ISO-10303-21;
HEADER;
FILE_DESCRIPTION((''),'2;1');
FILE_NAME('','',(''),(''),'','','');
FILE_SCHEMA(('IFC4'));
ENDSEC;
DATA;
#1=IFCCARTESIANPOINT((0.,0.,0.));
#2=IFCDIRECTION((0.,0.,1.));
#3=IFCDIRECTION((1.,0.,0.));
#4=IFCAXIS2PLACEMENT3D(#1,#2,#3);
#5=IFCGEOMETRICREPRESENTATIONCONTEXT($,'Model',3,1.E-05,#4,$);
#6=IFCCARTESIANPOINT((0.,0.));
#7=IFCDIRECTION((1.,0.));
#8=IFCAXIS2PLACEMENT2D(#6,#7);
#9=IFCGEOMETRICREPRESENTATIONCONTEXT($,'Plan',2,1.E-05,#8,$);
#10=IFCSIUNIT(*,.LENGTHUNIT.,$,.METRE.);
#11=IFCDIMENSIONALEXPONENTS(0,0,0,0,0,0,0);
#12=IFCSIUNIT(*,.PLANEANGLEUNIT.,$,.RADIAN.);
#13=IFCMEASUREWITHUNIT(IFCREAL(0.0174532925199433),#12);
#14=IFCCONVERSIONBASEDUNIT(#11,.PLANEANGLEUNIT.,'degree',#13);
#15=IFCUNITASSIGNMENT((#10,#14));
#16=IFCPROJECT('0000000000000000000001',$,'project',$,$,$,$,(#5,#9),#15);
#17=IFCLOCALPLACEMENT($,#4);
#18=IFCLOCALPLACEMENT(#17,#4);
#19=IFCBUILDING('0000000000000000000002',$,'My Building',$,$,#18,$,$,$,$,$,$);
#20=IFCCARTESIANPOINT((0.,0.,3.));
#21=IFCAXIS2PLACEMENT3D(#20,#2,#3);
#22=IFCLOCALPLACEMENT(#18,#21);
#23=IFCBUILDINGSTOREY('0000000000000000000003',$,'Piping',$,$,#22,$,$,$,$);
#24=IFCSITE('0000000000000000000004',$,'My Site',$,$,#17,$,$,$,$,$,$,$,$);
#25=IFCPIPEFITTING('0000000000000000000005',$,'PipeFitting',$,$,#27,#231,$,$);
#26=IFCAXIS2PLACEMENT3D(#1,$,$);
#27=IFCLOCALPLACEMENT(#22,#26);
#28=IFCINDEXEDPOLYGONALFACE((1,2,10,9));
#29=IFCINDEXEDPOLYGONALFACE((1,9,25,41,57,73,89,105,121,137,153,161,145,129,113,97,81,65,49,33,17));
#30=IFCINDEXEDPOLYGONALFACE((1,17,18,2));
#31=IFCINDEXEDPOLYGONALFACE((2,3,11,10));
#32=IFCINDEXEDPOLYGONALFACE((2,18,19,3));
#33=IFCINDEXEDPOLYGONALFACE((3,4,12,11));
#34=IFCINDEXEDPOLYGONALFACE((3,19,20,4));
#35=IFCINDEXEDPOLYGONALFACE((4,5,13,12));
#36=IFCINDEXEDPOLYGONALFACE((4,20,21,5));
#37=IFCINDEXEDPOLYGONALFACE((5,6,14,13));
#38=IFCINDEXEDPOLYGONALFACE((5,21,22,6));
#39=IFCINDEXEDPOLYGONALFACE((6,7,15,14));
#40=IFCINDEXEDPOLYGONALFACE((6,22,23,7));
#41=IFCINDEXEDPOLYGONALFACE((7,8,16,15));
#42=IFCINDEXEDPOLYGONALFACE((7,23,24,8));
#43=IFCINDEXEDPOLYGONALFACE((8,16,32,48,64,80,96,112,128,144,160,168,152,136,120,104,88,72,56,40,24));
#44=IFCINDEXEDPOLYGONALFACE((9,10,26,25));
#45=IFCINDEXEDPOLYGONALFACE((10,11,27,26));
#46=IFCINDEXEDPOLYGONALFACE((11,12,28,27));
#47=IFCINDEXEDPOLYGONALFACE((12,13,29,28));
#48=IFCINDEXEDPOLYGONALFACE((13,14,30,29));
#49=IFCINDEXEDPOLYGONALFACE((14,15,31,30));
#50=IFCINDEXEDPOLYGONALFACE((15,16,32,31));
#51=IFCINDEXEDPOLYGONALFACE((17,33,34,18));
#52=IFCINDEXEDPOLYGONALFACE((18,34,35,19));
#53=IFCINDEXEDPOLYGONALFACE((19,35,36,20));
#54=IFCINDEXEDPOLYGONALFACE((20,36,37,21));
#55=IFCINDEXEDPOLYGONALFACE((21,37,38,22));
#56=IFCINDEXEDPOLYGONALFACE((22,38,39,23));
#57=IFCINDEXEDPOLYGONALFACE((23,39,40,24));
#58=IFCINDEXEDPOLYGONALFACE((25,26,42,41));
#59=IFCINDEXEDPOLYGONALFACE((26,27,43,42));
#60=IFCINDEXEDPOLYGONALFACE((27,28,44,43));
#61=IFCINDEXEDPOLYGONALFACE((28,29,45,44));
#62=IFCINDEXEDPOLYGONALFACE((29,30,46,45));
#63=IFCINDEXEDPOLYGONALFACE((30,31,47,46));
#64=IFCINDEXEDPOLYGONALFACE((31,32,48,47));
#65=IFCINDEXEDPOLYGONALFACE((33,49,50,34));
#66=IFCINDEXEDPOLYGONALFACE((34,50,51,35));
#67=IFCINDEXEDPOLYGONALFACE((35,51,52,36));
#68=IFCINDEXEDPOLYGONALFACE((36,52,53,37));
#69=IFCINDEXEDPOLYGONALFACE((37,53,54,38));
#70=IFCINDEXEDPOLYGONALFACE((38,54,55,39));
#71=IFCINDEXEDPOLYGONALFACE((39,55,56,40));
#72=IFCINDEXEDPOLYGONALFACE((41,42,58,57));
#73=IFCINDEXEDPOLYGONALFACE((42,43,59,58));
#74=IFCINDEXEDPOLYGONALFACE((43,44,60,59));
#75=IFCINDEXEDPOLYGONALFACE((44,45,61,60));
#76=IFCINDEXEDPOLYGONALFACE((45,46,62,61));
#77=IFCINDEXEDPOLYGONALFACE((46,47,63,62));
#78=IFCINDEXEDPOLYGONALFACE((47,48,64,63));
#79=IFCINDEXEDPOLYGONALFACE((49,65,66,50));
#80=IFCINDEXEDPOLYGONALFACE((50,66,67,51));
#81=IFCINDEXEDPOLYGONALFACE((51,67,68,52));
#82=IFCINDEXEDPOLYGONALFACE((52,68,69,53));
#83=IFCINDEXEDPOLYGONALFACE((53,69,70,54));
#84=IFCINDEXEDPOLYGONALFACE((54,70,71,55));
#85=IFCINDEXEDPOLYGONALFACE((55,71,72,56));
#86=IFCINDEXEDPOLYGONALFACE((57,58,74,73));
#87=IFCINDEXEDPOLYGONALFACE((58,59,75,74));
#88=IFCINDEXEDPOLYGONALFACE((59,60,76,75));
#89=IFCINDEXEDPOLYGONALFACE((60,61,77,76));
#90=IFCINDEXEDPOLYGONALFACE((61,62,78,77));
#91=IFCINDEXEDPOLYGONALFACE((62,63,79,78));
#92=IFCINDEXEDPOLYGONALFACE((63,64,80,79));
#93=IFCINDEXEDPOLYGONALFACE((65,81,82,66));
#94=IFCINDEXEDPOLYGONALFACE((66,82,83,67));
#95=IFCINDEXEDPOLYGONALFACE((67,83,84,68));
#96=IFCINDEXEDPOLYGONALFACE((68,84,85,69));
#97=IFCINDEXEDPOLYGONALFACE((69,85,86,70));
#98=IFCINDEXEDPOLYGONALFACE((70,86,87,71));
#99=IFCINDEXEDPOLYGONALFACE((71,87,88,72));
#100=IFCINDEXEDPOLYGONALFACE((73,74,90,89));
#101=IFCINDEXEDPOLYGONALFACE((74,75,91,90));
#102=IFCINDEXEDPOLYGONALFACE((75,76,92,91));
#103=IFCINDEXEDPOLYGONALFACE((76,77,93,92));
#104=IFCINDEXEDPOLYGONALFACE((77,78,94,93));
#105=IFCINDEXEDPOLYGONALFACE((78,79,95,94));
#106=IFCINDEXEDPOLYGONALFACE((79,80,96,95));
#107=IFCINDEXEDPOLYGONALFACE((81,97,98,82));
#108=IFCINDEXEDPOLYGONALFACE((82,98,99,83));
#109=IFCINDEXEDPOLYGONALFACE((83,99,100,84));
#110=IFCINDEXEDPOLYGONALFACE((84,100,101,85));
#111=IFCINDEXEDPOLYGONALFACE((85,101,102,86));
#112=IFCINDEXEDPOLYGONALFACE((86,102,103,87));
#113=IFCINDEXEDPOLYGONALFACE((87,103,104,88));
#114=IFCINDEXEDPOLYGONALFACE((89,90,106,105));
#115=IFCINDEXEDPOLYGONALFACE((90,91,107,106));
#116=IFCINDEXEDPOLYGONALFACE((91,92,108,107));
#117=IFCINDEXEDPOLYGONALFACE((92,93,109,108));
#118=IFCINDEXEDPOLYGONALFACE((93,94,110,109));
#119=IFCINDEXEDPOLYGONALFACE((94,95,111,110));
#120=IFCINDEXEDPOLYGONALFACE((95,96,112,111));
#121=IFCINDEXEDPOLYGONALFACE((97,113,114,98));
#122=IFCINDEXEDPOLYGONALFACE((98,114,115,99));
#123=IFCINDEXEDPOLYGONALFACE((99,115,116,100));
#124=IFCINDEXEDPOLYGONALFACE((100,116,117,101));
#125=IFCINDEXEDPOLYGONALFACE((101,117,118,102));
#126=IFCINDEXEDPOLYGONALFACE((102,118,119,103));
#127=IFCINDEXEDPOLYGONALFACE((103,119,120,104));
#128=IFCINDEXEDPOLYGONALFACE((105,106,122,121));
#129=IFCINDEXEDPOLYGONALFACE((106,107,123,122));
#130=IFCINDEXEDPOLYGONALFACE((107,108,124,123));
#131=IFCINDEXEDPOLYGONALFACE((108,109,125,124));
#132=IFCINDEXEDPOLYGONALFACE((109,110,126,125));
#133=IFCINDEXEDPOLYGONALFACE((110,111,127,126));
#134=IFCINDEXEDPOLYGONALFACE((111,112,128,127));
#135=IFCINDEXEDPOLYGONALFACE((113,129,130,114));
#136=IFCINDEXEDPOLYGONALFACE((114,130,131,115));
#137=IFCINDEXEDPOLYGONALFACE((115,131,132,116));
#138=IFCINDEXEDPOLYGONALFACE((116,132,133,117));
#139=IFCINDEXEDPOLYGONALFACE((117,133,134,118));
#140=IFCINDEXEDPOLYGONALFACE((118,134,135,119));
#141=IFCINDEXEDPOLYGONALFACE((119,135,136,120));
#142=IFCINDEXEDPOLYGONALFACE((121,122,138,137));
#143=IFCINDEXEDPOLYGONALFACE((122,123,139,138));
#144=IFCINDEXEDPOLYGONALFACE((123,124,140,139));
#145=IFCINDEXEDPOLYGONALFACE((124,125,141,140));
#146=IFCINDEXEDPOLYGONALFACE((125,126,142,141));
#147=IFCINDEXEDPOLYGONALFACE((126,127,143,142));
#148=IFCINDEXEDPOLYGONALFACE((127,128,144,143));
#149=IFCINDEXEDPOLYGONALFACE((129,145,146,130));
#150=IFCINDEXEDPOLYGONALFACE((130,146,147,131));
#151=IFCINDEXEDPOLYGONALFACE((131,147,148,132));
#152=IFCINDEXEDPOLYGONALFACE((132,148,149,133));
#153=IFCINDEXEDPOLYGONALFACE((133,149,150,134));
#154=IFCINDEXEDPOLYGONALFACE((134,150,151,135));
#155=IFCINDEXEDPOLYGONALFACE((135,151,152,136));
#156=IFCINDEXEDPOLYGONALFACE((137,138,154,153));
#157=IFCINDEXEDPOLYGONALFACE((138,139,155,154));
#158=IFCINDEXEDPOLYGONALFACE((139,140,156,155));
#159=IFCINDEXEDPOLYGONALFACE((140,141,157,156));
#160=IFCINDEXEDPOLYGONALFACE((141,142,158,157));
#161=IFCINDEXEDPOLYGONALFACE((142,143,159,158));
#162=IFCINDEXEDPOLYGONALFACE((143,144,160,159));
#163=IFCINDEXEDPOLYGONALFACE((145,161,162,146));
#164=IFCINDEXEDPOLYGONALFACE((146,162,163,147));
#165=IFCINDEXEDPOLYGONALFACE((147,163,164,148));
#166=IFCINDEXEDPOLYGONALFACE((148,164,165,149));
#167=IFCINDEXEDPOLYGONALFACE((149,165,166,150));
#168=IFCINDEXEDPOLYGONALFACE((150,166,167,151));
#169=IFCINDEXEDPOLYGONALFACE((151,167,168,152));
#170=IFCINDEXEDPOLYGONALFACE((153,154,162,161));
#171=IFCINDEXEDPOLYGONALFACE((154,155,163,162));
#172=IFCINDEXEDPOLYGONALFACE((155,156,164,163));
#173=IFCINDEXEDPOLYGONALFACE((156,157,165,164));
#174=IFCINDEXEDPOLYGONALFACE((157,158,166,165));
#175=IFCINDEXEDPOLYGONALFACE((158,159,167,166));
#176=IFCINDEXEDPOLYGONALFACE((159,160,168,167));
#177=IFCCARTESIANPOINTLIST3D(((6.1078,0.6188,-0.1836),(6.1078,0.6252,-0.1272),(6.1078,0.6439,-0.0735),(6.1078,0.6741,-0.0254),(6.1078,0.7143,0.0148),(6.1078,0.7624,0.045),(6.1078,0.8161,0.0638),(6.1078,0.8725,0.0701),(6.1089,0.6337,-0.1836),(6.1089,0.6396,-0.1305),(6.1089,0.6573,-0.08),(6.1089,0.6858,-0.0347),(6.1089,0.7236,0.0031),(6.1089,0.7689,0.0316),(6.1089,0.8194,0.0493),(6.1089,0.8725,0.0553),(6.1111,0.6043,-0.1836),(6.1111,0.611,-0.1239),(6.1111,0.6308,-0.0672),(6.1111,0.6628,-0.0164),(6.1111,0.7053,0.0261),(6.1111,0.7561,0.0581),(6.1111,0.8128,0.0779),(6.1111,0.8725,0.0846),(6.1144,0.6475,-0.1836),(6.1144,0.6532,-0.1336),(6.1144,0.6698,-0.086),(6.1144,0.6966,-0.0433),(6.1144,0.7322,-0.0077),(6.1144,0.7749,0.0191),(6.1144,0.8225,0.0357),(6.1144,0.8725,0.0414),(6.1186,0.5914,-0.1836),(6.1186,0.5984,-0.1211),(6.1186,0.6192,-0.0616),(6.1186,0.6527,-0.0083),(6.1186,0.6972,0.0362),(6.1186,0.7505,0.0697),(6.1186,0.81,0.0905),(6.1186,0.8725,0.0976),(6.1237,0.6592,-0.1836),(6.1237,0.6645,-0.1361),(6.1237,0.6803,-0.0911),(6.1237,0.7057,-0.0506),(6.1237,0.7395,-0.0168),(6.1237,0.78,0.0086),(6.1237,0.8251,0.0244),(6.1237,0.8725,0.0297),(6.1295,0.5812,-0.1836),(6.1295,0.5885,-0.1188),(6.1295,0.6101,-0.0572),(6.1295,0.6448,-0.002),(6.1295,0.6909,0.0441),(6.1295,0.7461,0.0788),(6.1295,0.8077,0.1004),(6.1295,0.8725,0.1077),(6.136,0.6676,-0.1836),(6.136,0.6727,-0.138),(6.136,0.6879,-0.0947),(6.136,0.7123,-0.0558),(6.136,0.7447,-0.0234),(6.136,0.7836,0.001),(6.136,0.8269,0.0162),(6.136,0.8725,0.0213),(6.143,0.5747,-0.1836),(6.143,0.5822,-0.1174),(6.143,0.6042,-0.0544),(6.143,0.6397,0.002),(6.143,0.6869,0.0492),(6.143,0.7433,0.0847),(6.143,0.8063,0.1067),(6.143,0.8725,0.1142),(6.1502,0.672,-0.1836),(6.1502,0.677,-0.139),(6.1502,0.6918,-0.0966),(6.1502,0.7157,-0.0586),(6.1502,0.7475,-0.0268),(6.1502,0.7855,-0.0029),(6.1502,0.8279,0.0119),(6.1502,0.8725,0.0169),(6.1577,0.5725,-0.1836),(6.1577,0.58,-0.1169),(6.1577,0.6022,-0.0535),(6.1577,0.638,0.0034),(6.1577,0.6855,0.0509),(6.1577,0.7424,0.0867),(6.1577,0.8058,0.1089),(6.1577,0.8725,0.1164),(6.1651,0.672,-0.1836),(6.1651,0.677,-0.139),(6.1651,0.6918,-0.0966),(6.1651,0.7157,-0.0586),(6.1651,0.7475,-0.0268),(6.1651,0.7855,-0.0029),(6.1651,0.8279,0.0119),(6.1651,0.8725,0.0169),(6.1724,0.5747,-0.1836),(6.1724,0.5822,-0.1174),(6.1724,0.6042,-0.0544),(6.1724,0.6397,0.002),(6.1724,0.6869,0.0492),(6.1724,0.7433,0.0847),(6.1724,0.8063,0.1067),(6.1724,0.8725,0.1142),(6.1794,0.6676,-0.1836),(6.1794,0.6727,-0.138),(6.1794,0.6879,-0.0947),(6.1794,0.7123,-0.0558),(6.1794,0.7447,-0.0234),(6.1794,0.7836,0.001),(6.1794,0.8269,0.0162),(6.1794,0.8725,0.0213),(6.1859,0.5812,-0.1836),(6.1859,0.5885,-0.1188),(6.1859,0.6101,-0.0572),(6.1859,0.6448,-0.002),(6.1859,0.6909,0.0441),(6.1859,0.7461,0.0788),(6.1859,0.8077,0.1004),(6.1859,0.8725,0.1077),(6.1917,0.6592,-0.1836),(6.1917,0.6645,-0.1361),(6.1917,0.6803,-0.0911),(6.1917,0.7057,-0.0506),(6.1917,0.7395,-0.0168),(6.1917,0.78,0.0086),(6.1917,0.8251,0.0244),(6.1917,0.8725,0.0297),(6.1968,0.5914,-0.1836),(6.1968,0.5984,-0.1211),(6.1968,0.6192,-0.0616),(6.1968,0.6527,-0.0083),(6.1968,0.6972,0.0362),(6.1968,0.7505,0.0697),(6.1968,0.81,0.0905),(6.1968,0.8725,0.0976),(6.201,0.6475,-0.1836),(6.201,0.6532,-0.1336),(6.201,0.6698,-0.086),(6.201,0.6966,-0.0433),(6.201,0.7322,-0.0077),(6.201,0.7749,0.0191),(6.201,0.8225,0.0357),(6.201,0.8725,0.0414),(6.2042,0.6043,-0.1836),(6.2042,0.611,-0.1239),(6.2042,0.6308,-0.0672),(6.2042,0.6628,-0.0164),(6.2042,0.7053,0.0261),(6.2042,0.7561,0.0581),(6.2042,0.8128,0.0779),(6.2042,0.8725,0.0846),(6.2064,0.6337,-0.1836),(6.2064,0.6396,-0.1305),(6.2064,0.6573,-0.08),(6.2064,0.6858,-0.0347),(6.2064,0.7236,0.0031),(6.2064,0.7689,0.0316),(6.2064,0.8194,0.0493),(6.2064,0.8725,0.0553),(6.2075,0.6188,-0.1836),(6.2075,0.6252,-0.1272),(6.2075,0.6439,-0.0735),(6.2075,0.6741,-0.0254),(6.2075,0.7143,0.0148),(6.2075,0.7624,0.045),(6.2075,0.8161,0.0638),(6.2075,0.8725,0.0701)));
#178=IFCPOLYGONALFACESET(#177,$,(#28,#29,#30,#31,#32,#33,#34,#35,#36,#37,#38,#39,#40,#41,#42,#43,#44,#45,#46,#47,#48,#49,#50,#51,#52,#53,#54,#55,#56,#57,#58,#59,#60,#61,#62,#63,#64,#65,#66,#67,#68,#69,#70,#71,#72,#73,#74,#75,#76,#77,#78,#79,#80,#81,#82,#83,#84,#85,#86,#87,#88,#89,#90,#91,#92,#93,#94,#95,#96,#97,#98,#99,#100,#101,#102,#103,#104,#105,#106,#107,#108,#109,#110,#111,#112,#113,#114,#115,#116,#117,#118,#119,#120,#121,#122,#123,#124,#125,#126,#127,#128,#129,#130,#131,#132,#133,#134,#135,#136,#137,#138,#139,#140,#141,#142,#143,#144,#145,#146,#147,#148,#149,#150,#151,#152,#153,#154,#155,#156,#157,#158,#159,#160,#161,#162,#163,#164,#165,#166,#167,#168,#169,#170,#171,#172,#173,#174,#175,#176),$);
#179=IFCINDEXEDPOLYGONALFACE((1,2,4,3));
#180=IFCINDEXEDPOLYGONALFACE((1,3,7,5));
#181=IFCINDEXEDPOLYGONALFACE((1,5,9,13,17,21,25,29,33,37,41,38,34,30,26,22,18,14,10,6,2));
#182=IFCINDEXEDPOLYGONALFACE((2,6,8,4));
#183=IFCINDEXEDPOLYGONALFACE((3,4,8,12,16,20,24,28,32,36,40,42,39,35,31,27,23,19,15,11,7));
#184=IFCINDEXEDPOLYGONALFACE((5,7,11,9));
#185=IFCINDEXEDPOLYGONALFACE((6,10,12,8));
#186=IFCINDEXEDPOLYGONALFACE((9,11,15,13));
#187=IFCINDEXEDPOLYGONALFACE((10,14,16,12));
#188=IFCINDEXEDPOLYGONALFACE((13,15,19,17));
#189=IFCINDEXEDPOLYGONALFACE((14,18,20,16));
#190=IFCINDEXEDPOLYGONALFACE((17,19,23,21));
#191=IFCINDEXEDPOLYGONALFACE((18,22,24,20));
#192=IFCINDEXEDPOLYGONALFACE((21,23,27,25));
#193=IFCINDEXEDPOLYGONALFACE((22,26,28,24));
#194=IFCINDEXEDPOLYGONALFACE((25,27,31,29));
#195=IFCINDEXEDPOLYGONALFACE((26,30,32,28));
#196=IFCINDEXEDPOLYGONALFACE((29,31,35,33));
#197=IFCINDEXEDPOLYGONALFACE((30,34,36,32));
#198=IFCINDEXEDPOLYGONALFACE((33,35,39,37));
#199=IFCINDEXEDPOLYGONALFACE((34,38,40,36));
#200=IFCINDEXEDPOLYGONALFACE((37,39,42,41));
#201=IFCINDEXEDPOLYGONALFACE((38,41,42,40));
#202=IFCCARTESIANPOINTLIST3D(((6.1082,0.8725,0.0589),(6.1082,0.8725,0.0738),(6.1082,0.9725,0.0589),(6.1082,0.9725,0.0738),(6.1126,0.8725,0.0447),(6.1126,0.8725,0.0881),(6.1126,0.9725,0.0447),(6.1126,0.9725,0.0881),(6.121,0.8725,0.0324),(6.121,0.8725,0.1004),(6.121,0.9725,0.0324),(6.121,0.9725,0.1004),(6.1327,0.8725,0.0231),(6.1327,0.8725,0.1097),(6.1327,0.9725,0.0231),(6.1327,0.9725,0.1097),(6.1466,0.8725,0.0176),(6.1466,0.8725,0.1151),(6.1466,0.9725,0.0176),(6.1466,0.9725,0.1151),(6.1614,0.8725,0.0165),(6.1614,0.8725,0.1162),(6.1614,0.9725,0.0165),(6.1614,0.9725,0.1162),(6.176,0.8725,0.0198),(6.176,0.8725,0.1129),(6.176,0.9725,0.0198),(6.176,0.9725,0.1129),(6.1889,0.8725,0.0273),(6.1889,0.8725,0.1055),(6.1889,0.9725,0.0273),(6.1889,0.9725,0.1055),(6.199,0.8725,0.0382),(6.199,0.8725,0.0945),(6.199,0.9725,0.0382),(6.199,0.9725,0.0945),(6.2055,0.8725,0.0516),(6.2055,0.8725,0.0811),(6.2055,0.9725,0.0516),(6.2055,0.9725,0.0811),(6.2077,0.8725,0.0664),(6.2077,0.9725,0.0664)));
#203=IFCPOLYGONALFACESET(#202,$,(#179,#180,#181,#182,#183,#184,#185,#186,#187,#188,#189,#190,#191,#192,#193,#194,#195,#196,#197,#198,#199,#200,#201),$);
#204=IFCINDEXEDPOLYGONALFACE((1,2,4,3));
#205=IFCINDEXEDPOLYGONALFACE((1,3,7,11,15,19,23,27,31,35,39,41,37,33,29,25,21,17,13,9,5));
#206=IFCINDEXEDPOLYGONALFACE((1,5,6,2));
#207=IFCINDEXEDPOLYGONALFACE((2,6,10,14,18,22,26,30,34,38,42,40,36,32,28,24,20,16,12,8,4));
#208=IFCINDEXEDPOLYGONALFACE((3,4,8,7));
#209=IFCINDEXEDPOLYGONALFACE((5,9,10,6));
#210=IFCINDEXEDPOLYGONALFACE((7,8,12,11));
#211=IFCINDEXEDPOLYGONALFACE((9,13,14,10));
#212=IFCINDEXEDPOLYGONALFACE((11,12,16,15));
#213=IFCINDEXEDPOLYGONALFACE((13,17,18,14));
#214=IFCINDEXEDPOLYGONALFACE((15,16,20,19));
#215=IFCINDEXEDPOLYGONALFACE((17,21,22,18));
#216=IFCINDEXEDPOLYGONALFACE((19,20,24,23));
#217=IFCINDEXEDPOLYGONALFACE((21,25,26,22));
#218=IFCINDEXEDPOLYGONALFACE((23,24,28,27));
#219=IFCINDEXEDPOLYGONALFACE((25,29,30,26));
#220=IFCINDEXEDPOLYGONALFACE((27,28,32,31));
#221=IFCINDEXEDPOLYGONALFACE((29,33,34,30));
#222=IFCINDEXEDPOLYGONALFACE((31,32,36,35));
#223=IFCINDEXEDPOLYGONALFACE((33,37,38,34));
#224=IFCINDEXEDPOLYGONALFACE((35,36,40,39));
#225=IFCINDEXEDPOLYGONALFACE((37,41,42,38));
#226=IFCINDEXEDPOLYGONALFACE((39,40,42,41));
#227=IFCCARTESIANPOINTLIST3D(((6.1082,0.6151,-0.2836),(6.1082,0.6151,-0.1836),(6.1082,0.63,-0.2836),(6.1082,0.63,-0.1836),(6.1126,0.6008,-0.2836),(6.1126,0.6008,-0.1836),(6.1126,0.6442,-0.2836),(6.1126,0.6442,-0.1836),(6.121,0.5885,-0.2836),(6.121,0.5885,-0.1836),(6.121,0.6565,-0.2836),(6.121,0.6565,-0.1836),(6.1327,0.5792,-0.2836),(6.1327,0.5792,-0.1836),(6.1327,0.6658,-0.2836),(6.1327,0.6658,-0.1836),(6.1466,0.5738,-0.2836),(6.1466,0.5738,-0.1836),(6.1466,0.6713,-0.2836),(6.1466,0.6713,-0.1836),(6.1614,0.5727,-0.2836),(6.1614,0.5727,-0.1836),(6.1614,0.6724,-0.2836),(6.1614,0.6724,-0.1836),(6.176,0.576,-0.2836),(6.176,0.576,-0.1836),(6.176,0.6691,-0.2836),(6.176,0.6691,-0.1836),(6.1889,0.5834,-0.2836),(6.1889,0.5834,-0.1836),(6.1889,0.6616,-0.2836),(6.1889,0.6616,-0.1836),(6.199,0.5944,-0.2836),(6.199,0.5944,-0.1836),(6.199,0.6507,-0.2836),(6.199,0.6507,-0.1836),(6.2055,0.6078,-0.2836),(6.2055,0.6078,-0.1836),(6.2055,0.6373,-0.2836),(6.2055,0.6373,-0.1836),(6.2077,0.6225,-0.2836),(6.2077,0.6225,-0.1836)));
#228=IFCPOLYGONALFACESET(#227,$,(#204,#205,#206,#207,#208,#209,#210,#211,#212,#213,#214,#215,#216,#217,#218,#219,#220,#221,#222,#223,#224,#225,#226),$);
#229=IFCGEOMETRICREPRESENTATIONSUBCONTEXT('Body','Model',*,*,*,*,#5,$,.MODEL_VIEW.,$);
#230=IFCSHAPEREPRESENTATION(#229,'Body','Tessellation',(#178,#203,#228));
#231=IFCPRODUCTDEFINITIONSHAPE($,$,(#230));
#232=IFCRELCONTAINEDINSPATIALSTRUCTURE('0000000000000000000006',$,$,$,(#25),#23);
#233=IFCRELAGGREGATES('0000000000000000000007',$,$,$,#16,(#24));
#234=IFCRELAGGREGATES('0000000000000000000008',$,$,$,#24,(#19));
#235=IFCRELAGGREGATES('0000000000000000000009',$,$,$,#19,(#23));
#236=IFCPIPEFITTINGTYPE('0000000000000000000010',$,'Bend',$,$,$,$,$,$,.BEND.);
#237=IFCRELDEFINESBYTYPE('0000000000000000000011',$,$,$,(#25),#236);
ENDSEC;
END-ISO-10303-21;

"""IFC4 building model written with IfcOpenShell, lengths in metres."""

from ifc_helpers import new_model, entity, si_unit, converted_unit, frame, origin_with_axes, origin_2d_with_axis, place, context, subcontext, project, spatial, circle, extrude, source, transform, mapped, type_object, type_shapes, element, save


model = new_model("IFC4")

# Units and contexts
model_context = context("Model", 3, precision=1e-05, world=origin_with_axes())
plan_context = context("Plan", 2, precision=1e-05, world=origin_2d_with_axis())
body_context = subcontext(model_context, "Body", "Model", "MODEL_VIEW")
ifc_project = project(units=[si_unit("LENGTHUNIT", "METRE"), converted_unit("PLANEANGLEUNIT", "degree", entity("IfcReal", 0.0174532925199433), si_unit("PLANEANGLEUNIT", "RADIAN"), dimensions=[0, 0, 0, 0, 0, 0, 0])], contexts=[model_context, plan_context])

# Site, building, storey
site_placement = place(None, origin_with_axes())
site = spatial("IfcSite", under=ifc_project, at=site_placement, Name="My Site")
building_placement = place(site_placement, origin_with_axes())
building = spatial("IfcBuilding", under=site, at=building_placement, Name="My Building")
storey_placement = place(building_placement, frame((0.0, 0.0, 3.0), z_axis=(0.0, 0.0, 1.0), x_axis=(1.0, 0.0, 0.0)))
storey = spatial("IfcBuildingStorey", under=building, at=storey_placement, Name="Piping")

# Pipe fitting
pipe_fitting_type_1 = type_object("IfcPipeFittingType", Name="Bend", PredefinedType="BEND")
shared_shape = source(origin_with_axes(), body_context, "Body", "SolidModel", [
    entity("IfcSweptDiskSolid", entity("IfcIndexedPolyCurve", entity("IfcCartesianPointList3D", [[0.0, 0.0, 0.1], [0.0, -0.0732, 0.2768], [0.0, -0.25, 0.35]]), [entity("IfcArcIndex", [1, 2, 3])]), 0.05),
    extrude(circle(Radius=0.05), origin_with_axes(), (0.0, 0.0, 1.0), 0.1),
    extrude(circle(Radius=0.05), frame((0.0, -0.25, 0.35), z_axis=(0.0, -1.0, -0.000002), x_axis=(1.0, 0.0, 0.0)), (0.0, 0.0, 1.0), 0.1),
])
type_shapes(pipe_fitting_type_1, [shared_shape])
for number, where, z_axis, x_axis, name in (
    (1, (6.1577, 0.9725, 0.0664), (0.0, -1.0, 0.000002), (1.0, 0.0, 0.0), "PipeFitting"),
):
    element("IfcPipeFitting", number, at=place(storey_placement, frame(where, z_axis=z_axis, x_axis=x_axis)), inside=storey, type_object=pipe_fitting_type_1, Name=name, context=body_context, shape_type="MappedRepresentation", body=[
        mapped(shared_shape, transform((0.0, 0.0, 0.0), x_axis=(1.0, 0.0, 0.0), y_axis=(0.0, 1.0, 0.0), z_axis=(0.0, 0.0, 1.0), scale=1.0)),
    ])

save(model, "model.ifc")
